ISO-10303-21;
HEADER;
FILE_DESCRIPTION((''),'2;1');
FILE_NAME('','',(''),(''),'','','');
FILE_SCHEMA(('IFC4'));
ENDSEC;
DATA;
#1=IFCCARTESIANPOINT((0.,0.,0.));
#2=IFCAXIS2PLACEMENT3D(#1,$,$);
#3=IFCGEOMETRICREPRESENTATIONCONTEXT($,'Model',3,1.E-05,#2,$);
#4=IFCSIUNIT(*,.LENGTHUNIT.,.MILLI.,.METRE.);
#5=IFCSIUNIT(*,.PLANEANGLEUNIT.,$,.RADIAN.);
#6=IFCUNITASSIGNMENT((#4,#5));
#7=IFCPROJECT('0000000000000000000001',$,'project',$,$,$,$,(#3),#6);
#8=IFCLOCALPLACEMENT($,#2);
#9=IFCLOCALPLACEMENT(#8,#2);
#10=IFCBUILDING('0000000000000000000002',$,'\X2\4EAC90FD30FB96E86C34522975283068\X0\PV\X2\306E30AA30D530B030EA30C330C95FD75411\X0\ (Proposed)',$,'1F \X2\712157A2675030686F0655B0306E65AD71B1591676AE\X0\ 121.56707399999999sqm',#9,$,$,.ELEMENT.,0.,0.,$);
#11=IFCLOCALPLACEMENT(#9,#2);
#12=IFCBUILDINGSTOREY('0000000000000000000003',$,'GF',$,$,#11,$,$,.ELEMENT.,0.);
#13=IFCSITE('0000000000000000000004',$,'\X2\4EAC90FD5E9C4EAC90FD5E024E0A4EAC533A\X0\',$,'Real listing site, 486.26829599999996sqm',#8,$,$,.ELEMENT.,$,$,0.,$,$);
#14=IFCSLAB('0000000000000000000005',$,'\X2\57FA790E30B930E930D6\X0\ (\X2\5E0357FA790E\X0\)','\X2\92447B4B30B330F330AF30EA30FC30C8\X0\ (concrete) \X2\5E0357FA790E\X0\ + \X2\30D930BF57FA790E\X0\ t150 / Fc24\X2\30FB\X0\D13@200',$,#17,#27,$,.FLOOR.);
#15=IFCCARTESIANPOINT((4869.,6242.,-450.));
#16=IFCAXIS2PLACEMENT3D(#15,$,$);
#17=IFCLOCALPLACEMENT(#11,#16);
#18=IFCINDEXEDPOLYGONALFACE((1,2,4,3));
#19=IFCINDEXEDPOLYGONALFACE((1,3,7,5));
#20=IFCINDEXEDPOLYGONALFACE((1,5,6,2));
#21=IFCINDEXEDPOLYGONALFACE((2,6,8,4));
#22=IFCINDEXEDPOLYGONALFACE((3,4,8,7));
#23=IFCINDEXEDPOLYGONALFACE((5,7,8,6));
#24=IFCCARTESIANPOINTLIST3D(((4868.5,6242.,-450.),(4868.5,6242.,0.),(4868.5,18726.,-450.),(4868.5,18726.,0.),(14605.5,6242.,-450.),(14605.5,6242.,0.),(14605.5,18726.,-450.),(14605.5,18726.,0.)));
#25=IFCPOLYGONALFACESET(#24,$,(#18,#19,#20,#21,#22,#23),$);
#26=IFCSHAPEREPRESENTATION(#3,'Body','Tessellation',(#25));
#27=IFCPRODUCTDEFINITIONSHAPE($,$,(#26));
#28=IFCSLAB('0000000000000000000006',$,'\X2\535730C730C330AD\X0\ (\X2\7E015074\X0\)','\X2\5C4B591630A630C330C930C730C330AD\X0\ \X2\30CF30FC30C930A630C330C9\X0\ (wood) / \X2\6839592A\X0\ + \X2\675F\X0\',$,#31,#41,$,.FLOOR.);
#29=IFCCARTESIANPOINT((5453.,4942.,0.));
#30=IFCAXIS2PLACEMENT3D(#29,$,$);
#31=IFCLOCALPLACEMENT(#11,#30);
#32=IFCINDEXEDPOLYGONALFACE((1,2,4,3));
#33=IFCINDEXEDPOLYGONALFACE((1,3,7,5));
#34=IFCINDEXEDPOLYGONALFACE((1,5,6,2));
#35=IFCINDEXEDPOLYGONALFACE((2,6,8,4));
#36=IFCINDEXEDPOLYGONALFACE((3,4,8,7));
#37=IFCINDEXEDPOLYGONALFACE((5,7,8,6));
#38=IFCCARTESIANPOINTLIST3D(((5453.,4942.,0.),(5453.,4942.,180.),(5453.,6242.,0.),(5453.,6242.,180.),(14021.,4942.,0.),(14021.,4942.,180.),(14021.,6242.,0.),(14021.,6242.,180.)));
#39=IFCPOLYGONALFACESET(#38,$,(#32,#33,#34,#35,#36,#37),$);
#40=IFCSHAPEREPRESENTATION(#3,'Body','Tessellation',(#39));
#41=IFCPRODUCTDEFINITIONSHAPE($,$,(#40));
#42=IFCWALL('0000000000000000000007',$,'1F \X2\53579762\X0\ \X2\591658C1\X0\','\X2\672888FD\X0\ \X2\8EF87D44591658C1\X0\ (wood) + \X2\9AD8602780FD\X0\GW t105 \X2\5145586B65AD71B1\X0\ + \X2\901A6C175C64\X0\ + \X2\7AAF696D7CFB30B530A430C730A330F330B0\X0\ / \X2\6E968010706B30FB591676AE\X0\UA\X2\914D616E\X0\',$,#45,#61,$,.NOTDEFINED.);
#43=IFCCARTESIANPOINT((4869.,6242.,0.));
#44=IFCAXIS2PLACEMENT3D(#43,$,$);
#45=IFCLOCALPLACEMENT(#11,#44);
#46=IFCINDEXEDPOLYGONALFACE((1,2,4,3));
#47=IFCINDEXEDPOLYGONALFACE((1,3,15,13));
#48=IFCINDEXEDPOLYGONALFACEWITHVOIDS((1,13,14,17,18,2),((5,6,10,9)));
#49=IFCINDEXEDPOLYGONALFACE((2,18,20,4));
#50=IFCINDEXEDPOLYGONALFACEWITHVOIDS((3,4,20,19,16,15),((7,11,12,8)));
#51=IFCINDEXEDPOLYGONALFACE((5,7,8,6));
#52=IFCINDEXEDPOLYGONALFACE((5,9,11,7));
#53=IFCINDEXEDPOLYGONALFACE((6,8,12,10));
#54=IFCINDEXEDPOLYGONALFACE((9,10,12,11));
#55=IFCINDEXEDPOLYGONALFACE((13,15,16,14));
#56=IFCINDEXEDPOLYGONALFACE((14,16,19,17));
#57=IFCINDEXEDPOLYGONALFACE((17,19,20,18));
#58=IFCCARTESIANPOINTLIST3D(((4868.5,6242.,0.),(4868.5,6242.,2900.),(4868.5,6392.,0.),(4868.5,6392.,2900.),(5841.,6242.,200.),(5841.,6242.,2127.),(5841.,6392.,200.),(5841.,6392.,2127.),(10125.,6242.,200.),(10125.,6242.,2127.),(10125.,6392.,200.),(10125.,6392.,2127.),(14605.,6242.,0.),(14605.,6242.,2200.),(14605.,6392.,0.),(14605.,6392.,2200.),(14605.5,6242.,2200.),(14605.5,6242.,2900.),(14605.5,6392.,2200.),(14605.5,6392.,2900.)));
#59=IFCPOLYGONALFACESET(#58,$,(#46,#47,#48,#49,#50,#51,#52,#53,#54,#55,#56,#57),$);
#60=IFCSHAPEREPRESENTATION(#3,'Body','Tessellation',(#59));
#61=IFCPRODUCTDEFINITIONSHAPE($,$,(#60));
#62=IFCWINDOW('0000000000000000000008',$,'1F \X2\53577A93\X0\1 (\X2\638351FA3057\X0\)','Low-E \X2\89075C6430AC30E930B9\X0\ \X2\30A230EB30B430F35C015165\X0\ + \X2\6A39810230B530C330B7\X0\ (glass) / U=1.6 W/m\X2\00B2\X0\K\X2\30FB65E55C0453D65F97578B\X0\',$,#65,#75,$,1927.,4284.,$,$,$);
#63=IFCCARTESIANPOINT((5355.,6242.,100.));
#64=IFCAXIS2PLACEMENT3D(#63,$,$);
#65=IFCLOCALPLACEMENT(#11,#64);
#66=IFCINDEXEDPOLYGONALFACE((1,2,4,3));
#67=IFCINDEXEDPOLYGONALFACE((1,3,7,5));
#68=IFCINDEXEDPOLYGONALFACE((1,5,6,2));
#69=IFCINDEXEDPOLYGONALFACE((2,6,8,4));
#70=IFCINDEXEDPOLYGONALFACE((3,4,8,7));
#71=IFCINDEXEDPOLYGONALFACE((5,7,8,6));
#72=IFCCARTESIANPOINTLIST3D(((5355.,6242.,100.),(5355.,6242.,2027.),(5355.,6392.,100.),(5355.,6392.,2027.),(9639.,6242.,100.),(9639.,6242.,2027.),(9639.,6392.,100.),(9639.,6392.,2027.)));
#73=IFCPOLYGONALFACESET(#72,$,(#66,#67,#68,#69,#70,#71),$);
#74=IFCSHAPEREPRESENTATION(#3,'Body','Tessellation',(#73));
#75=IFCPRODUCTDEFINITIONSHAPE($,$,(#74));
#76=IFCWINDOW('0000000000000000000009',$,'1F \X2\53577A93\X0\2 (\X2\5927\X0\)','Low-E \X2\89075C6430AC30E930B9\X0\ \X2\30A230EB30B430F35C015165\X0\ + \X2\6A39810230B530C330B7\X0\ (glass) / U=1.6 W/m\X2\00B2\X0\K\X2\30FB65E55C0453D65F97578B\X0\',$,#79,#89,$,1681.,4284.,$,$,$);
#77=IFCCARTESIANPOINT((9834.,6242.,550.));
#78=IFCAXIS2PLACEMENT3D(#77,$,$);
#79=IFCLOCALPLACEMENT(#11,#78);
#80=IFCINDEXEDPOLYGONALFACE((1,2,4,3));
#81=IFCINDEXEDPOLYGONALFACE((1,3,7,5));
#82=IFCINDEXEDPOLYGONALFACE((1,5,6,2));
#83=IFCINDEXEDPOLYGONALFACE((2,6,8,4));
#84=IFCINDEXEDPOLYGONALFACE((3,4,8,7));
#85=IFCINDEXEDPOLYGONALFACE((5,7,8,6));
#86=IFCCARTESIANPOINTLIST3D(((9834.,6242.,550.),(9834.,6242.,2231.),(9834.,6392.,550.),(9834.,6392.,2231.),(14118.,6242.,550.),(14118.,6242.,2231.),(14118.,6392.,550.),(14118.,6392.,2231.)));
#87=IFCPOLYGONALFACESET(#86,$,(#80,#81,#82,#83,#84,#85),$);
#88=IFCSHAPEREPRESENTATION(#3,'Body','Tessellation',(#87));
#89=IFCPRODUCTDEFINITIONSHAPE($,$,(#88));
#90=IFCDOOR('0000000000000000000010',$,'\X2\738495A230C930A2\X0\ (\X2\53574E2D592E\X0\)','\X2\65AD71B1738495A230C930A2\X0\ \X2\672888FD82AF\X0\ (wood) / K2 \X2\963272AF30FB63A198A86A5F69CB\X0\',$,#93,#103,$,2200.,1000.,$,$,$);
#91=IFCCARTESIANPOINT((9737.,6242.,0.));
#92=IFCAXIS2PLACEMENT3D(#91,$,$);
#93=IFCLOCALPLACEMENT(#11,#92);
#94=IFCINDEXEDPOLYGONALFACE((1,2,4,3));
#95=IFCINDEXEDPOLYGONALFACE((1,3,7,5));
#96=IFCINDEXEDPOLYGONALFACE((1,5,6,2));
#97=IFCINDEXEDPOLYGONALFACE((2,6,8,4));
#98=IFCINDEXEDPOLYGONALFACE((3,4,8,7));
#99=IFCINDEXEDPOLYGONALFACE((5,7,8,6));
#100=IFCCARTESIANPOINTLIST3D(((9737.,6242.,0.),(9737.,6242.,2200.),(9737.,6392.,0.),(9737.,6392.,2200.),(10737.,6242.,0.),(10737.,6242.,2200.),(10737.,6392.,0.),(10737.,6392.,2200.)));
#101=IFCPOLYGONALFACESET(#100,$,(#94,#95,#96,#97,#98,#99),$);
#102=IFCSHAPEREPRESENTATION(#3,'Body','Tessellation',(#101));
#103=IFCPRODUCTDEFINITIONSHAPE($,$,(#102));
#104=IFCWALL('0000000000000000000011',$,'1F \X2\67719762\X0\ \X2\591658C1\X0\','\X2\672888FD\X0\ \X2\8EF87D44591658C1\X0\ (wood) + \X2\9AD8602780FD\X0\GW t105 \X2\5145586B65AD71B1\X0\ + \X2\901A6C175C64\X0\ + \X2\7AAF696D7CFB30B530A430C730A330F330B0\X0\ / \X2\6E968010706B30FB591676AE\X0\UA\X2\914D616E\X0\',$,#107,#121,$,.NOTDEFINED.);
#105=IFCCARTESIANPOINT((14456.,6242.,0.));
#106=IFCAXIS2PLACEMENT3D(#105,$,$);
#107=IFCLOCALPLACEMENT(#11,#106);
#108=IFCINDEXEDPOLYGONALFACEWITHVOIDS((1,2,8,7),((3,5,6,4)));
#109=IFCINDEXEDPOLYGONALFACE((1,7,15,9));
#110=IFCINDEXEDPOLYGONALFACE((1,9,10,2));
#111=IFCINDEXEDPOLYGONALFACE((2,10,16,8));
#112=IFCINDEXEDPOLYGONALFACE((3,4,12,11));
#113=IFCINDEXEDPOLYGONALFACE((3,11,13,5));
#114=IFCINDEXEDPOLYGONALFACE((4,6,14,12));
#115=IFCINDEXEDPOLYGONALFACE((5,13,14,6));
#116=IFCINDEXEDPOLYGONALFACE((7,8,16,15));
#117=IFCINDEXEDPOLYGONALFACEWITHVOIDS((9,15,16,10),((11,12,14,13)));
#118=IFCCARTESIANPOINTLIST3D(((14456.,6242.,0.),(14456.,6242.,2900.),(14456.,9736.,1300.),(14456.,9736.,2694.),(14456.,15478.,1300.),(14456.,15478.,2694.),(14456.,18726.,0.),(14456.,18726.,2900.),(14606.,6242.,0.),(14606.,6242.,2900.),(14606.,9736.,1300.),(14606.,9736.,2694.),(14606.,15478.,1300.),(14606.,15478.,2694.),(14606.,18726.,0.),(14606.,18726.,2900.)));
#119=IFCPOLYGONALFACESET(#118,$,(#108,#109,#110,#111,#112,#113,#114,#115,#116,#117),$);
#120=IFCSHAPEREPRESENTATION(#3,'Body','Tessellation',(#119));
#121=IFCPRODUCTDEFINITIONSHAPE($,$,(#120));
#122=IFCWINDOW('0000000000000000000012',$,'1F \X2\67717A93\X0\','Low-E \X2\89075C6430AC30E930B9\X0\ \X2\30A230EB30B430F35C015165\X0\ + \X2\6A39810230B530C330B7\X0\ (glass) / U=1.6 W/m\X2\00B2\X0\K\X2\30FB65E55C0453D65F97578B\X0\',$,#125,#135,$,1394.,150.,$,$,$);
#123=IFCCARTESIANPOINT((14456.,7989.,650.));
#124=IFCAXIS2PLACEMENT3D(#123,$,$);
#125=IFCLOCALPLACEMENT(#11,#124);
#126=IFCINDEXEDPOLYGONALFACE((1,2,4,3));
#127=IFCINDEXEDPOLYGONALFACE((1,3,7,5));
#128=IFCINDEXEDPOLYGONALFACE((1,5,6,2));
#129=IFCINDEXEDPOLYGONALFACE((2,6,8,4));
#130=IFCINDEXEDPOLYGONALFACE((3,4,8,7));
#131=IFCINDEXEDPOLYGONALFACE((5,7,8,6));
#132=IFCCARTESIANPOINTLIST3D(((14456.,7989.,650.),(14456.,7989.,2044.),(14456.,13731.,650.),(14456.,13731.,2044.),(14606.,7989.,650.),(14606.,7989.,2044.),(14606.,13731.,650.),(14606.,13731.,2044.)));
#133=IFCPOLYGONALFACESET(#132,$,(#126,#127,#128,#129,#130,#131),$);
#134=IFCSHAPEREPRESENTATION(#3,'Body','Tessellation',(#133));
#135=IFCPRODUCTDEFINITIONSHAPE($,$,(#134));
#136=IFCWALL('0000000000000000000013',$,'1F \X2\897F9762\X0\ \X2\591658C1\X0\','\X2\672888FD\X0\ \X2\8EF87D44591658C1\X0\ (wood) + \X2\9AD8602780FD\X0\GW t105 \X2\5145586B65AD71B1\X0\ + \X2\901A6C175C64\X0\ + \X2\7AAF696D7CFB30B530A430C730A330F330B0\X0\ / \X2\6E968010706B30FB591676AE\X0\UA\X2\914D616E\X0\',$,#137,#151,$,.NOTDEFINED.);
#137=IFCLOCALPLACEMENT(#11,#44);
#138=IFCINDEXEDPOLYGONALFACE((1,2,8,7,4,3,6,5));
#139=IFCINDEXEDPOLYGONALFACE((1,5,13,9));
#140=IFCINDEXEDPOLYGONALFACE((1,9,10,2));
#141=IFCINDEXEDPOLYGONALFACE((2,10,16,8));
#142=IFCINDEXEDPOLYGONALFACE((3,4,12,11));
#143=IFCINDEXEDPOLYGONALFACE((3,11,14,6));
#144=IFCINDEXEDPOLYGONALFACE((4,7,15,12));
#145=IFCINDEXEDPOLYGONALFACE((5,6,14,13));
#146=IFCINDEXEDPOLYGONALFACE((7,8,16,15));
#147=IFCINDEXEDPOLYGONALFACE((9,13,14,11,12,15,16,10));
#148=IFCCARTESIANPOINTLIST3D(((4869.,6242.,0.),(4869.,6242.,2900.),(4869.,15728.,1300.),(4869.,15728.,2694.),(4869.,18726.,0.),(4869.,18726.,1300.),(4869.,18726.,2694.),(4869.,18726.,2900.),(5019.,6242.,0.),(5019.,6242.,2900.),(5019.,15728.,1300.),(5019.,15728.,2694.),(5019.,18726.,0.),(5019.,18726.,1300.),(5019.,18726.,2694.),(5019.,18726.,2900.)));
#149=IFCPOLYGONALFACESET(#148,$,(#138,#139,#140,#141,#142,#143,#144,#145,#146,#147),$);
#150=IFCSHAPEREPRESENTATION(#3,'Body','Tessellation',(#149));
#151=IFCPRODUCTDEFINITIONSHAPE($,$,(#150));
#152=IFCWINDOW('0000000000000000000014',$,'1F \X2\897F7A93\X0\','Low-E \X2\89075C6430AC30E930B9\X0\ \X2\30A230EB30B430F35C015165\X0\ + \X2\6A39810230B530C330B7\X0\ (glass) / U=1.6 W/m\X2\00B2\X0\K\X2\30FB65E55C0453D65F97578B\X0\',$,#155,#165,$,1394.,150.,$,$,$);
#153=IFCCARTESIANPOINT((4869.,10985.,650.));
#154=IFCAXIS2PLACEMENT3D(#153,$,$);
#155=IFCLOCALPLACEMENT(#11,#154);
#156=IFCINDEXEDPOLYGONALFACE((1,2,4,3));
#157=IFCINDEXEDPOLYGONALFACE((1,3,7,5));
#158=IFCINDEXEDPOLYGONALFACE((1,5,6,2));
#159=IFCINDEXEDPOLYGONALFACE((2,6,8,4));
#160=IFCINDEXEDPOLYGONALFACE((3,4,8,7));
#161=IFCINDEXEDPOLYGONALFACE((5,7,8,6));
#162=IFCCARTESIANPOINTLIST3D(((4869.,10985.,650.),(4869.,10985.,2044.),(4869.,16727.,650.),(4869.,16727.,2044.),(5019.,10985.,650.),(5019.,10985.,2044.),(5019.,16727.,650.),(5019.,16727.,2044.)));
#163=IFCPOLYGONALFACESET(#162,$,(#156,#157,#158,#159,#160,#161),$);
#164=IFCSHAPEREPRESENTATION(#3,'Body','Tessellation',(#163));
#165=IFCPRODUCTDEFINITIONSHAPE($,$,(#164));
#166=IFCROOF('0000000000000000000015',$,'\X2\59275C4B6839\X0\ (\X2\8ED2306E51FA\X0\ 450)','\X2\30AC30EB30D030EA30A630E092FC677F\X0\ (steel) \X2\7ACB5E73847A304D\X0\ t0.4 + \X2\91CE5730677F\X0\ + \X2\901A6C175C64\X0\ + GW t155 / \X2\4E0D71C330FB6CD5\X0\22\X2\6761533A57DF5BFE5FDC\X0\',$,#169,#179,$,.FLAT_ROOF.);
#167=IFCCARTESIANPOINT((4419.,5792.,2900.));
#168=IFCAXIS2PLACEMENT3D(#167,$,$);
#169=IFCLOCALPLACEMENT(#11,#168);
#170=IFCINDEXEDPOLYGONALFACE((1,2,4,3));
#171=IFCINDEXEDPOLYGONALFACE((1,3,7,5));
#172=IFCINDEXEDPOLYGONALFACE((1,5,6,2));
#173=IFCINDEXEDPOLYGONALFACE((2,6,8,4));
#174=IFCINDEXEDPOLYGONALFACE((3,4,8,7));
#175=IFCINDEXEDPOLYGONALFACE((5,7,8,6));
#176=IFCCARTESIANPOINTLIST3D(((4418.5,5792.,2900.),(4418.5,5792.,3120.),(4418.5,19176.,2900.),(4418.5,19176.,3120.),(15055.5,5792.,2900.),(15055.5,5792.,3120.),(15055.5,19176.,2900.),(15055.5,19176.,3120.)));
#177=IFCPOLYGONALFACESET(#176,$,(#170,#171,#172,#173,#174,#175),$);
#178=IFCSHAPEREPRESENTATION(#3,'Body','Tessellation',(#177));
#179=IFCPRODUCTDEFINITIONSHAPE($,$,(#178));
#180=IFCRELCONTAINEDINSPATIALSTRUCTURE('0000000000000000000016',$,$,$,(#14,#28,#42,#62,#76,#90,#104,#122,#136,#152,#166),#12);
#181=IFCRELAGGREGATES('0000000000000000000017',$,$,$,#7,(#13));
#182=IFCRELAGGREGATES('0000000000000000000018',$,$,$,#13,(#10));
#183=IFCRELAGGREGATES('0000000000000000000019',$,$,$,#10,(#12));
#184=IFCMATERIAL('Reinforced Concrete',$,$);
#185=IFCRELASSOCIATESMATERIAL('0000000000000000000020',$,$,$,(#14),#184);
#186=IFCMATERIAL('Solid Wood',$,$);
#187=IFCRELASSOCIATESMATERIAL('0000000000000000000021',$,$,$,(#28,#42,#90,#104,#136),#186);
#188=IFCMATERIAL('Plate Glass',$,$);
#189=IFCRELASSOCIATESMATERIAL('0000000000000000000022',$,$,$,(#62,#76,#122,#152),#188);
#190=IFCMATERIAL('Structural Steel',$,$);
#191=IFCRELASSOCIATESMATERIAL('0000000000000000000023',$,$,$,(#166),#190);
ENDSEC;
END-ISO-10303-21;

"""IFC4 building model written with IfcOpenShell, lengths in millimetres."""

from ifc_helpers import new_model, si_unit, frame, frame_2d, origin, place, context, project, spatial, rectangle, extrude, material, element, fill, save


model = new_model("IFC4")

# Units and contexts
model_context = context("Model", 3, precision=1e-05, world=origin())
ifc_project = project(units=[si_unit("LENGTHUNIT", "METRE", prefix="MILLI"), si_unit("PLANEANGLEUNIT", "RADIAN")], contexts=[model_context])

# Site, building, storey
site_placement = place(None, origin())
site = spatial("IfcSite", under=ifc_project, at=site_placement, Name="京都府京都市上京区", ObjectType="Real listing site, 486.26829599999996sqm", CompositionType="ELEMENT", RefElevation=0.0)
building_placement = place(site_placement, origin())
building = spatial("IfcBuilding", under=site, at=building_placement, Name="京都・雨水利用とPVのオフグリッド志向 (Proposed)", ObjectType="1F 無垢材と漆喰の断熱外皮 121.56707399999999sqm", CompositionType="ELEMENT", ElevationOfRefHeight=0.0, ElevationOfTerrain=0.0)
storey_placement = place(building_placement, origin())
storey = spatial("IfcBuildingStorey", under=building, at=storey_placement, Name="GF", CompositionType="ELEMENT", Elevation=0.0)

# Slabs
ifc_material_1 = material(Name="Reinforced Concrete")
slab_1_placement = place(storey_placement, frame((4869.0, 6242.0, -450.0)))
element("IfcSlab", 1, at=slab_1_placement, inside=storey, material=ifc_material_1, Name="基礎スラブ (布基礎)", Description="鉄筋コンクリート (concrete) 布基礎 + ベタ基礎 t150 / Fc24・D13@200", PredefinedType="FLOOR", context=model_context, shape_type="SweptSolid", body=[
    extrude(rectangle(XDim=9737.0, YDim=12484.0, at=frame_2d((4868.0, 6242.0))), frame((4869.0, 6242.0, -450.0)), (0.0, 0.0, 1.0), 450.0),
])
ifc_material_2 = material(Name="Solid Wood")
slab_2_placement = place(storey_placement, frame((5453.0, 4942.0, 0.0)))
element("IfcSlab", 2, at=slab_2_placement, inside=storey, material=ifc_material_2, Name="南デッキ (縁側)", Description="屋外ウッドデッキ ハードウッド (wood) / 根太 + 束", PredefinedType="FLOOR", context=model_context, shape_type="SweptSolid", body=[
    extrude(rectangle(XDim=8568.0, YDim=1300.0, at=frame_2d((4284.0, 650.0))), frame((5453.0, 4942.0, 0.0)), (0.0, 0.0, 1.0), 180.0),
])

# Wall, openings, windows, door
wall_1_placement = place(storey_placement, frame((4869.0, 6242.0, 0.0)))
wall_1 = element("IfcWall", 3, at=wall_1_placement, inside=storey, material=ifc_material_2, Name="1F 南面 外壁", Description="木製 軸組外壁 (wood) + 高性能GW t105 充填断熱 + 通気層 + 窯業系サイディング / 準耐火・外皮UA配慮", PredefinedType="NOTDEFINED", context=model_context, shape_type="SweptSolid", body=[
    extrude(rectangle(XDim=9737.0, YDim=150.0, at=frame_2d((4868.0, 75.0))), frame((4869.0, 6242.0, 0.0)), (0.0, 0.0, 1.0), 2900.0),
])
opening_1_placement = place(storey_placement, frame((5355.0, 6242.0, 100.0)))
opening_1 = element("IfcOpeningElement", 4, at=opening_1_placement, cuts=wall_1, PredefinedType="NOTDEFINED", context=model_context, shape_type="SweptSolid", body=[
    extrude(rectangle(XDim=4284.0, YDim=150.0, at=frame_2d((2142.0, 75.0))), frame((5355.0, 6242.0, 100.0)), (0.0, 0.0, 1.0), 1927.0),
])
opening_2_placement = place(storey_placement, frame((9834.0, 6242.0, 550.0)))
opening_2 = element("IfcOpeningElement", 5, at=opening_2_placement, cuts=wall_1, PredefinedType="NOTDEFINED", context=model_context, shape_type="SweptSolid", body=[
    extrude(rectangle(XDim=4284.0, YDim=150.0, at=frame_2d((2142.0, 75.0))), frame((9834.0, 6242.0, 550.0)), (0.0, 0.0, 1.0), 1681.0),
])
opening_3_placement = place(storey_placement, frame((9737.0, 6242.0, 0.0)))
opening_3 = element("IfcOpeningElement", 6, at=opening_3_placement, cuts=wall_1, PredefinedType="NOTDEFINED", context=model_context, shape_type="SweptSolid", body=[
    extrude(rectangle(XDim=1000.0, YDim=150.0, at=frame_2d((500.0, 75.0))), frame((9737.0, 6242.0, 0.0)), (0.0, 0.0, 1.0), 2200.0),
])
ifc_material_3 = material(Name="Plate Glass")
window_1_placement = place(storey_placement, frame((5355.0, 6242.0, 100.0)))
window_1 = element("IfcWindow", 7, at=window_1_placement, inside=storey, material=ifc_material_3, Name="1F 南窓1 (掃出し)", Description="Low-E 複層ガラス アルゴン封入 + 樹脂サッシ (glass) / U=1.6 W/m²K・日射取得型", OverallHeight=1927.0, OverallWidth=4284.0, context=model_context, shape_type="SweptSolid", body=[
    extrude(rectangle(XDim=4284.0, YDim=150.0, at=frame_2d((2142.0, 75.0))), frame((5355.0, 6242.0, 100.0)), (0.0, 0.0, 1.0), 1927.0),
])
fill(opening_1, window_1)
window_2_placement = place(storey_placement, frame((9834.0, 6242.0, 550.0)))
window_2 = element("IfcWindow", 8, at=window_2_placement, inside=storey, material=ifc_material_3, Name="1F 南窓2 (大)", Description="Low-E 複層ガラス アルゴン封入 + 樹脂サッシ (glass) / U=1.6 W/m²K・日射取得型", OverallHeight=1681.0, OverallWidth=4284.0, context=model_context, shape_type="SweptSolid", body=[
    extrude(rectangle(XDim=4284.0, YDim=150.0, at=frame_2d((2142.0, 75.0))), frame((9834.0, 6242.0, 550.0)), (0.0, 0.0, 1.0), 1681.0),
])
fill(opening_2, window_2)
door_placement = place(storey_placement, frame((9737.0, 6242.0, 0.0)))
door = element("IfcDoor", 9, at=door_placement, inside=storey, material=ifc_material_2, Name="玄関ドア (南中央)", Description="断熱玄関ドア 木製芯 (wood) / K2 防犯・採風機構", OverallHeight=2200.0, OverallWidth=1000.0, context=model_context, shape_type="SweptSolid", body=[
    extrude(rectangle(XDim=1000.0, YDim=150.0, at=frame_2d((500.0, 75.0))), frame((9737.0, 6242.0, 0.0)), (0.0, 0.0, 1.0), 2200.0),
])
fill(opening_3, door)

# Walls, openings, windows
wall_2_placement = place(storey_placement, frame((14456.0, 6242.0, 0.0)))
wall_2 = element("IfcWall", 10, at=wall_2_placement, inside=storey, material=ifc_material_2, Name="1F 東面 外壁", Description="木製 軸組外壁 (wood) + 高性能GW t105 充填断熱 + 通気層 + 窯業系サイディング / 準耐火・外皮UA配慮", PredefinedType="NOTDEFINED", context=model_context, shape_type="SweptSolid", body=[
    extrude(rectangle(XDim=150.0, YDim=12484.0, at=frame_2d((75.0, 6242.0))), frame((14456.0, 6242.0, 0.0)), (0.0, 0.0, 1.0), 2900.0),
])
opening_4_placement = place(storey_placement, frame((14456.0, 7989.0, 650.0)))
opening_4 = element("IfcOpeningElement", 11, at=opening_4_placement, cuts=wall_2, PredefinedType="NOTDEFINED", context=model_context, shape_type="SweptSolid", body=[
    extrude(rectangle(XDim=150.0, YDim=5742.0, at=frame_2d((75.0, 2871.0))), frame((14456.0, 7989.0, 650.0)), (0.0, 0.0, 1.0), 1394.0),
])
window_3_placement = place(storey_placement, frame((14456.0, 7989.0, 650.0)))
window_3 = element("IfcWindow", 12, at=window_3_placement, inside=storey, material=ifc_material_3, Name="1F 東窓", Description="Low-E 複層ガラス アルゴン封入 + 樹脂サッシ (glass) / U=1.6 W/m²K・日射取得型", OverallHeight=1394.0, OverallWidth=150.0, context=model_context, shape_type="SweptSolid", body=[
    extrude(rectangle(XDim=150.0, YDim=5742.0, at=frame_2d((75.0, 2871.0))), frame((14456.0, 7989.0, 650.0)), (0.0, 0.0, 1.0), 1394.0),
])
fill(opening_4, window_3)
wall_3_placement = place(storey_placement, frame((4869.0, 6242.0, 0.0)))
wall_3 = element("IfcWall", 13, at=wall_3_placement, inside=storey, material=ifc_material_2, Name="1F 西面 外壁", Description="木製 軸組外壁 (wood) + 高性能GW t105 充填断熱 + 通気層 + 窯業系サイディング / 準耐火・外皮UA配慮", PredefinedType="NOTDEFINED", context=model_context, shape_type="SweptSolid", body=[
    extrude(rectangle(XDim=150.0, YDim=12484.0, at=frame_2d((75.0, 6242.0))), frame((4869.0, 6242.0, 0.0)), (0.0, 0.0, 1.0), 2900.0),
])
opening_5_placement = place(storey_placement, frame((4869.0, 10985.0, 650.0)))
opening_5 = element("IfcOpeningElement", 14, at=opening_5_placement, cuts=wall_3, PredefinedType="NOTDEFINED", context=model_context, shape_type="SweptSolid", body=[
    extrude(rectangle(XDim=150.0, YDim=5742.0, at=frame_2d((75.0, 2871.0))), frame((4869.0, 10985.0, 650.0)), (0.0, 0.0, 1.0), 1394.0),
])
window_4_placement = place(storey_placement, frame((4869.0, 10985.0, 650.0)))
window_4 = element("IfcWindow", 15, at=window_4_placement, inside=storey, material=ifc_material_3, Name="1F 西窓", Description="Low-E 複層ガラス アルゴン封入 + 樹脂サッシ (glass) / U=1.6 W/m²K・日射取得型", OverallHeight=1394.0, OverallWidth=150.0, context=model_context, shape_type="SweptSolid", body=[
    extrude(rectangle(XDim=150.0, YDim=5742.0, at=frame_2d((75.0, 2871.0))), frame((4869.0, 10985.0, 650.0)), (0.0, 0.0, 1.0), 1394.0),
])
fill(opening_5, window_4)

# Roof
ifc_material_4 = material(Name="Structural Steel")
roof_placement = place(storey_placement, frame((4419.0, 5792.0, 2900.0)))
element("IfcRoof", 16, at=roof_placement, inside=storey, material=ifc_material_4, Name="大屋根 (軒の出 450)", Description="ガルバリウム鋼板 (steel) 立平葺き t0.4 + 野地板 + 通気層 + GW t155 / 不燃・法22条区域対応", PredefinedType="FLAT_ROOF", context=model_context, shape_type="SweptSolid", body=[
    extrude(rectangle(XDim=10637.0, YDim=13384.0, at=frame_2d((5318.0, 6692.0))), frame((4419.0, 5792.0, 2900.0)), (0.0, 0.0, 1.0), 220.0),
])

save(model, "model.ifc")
